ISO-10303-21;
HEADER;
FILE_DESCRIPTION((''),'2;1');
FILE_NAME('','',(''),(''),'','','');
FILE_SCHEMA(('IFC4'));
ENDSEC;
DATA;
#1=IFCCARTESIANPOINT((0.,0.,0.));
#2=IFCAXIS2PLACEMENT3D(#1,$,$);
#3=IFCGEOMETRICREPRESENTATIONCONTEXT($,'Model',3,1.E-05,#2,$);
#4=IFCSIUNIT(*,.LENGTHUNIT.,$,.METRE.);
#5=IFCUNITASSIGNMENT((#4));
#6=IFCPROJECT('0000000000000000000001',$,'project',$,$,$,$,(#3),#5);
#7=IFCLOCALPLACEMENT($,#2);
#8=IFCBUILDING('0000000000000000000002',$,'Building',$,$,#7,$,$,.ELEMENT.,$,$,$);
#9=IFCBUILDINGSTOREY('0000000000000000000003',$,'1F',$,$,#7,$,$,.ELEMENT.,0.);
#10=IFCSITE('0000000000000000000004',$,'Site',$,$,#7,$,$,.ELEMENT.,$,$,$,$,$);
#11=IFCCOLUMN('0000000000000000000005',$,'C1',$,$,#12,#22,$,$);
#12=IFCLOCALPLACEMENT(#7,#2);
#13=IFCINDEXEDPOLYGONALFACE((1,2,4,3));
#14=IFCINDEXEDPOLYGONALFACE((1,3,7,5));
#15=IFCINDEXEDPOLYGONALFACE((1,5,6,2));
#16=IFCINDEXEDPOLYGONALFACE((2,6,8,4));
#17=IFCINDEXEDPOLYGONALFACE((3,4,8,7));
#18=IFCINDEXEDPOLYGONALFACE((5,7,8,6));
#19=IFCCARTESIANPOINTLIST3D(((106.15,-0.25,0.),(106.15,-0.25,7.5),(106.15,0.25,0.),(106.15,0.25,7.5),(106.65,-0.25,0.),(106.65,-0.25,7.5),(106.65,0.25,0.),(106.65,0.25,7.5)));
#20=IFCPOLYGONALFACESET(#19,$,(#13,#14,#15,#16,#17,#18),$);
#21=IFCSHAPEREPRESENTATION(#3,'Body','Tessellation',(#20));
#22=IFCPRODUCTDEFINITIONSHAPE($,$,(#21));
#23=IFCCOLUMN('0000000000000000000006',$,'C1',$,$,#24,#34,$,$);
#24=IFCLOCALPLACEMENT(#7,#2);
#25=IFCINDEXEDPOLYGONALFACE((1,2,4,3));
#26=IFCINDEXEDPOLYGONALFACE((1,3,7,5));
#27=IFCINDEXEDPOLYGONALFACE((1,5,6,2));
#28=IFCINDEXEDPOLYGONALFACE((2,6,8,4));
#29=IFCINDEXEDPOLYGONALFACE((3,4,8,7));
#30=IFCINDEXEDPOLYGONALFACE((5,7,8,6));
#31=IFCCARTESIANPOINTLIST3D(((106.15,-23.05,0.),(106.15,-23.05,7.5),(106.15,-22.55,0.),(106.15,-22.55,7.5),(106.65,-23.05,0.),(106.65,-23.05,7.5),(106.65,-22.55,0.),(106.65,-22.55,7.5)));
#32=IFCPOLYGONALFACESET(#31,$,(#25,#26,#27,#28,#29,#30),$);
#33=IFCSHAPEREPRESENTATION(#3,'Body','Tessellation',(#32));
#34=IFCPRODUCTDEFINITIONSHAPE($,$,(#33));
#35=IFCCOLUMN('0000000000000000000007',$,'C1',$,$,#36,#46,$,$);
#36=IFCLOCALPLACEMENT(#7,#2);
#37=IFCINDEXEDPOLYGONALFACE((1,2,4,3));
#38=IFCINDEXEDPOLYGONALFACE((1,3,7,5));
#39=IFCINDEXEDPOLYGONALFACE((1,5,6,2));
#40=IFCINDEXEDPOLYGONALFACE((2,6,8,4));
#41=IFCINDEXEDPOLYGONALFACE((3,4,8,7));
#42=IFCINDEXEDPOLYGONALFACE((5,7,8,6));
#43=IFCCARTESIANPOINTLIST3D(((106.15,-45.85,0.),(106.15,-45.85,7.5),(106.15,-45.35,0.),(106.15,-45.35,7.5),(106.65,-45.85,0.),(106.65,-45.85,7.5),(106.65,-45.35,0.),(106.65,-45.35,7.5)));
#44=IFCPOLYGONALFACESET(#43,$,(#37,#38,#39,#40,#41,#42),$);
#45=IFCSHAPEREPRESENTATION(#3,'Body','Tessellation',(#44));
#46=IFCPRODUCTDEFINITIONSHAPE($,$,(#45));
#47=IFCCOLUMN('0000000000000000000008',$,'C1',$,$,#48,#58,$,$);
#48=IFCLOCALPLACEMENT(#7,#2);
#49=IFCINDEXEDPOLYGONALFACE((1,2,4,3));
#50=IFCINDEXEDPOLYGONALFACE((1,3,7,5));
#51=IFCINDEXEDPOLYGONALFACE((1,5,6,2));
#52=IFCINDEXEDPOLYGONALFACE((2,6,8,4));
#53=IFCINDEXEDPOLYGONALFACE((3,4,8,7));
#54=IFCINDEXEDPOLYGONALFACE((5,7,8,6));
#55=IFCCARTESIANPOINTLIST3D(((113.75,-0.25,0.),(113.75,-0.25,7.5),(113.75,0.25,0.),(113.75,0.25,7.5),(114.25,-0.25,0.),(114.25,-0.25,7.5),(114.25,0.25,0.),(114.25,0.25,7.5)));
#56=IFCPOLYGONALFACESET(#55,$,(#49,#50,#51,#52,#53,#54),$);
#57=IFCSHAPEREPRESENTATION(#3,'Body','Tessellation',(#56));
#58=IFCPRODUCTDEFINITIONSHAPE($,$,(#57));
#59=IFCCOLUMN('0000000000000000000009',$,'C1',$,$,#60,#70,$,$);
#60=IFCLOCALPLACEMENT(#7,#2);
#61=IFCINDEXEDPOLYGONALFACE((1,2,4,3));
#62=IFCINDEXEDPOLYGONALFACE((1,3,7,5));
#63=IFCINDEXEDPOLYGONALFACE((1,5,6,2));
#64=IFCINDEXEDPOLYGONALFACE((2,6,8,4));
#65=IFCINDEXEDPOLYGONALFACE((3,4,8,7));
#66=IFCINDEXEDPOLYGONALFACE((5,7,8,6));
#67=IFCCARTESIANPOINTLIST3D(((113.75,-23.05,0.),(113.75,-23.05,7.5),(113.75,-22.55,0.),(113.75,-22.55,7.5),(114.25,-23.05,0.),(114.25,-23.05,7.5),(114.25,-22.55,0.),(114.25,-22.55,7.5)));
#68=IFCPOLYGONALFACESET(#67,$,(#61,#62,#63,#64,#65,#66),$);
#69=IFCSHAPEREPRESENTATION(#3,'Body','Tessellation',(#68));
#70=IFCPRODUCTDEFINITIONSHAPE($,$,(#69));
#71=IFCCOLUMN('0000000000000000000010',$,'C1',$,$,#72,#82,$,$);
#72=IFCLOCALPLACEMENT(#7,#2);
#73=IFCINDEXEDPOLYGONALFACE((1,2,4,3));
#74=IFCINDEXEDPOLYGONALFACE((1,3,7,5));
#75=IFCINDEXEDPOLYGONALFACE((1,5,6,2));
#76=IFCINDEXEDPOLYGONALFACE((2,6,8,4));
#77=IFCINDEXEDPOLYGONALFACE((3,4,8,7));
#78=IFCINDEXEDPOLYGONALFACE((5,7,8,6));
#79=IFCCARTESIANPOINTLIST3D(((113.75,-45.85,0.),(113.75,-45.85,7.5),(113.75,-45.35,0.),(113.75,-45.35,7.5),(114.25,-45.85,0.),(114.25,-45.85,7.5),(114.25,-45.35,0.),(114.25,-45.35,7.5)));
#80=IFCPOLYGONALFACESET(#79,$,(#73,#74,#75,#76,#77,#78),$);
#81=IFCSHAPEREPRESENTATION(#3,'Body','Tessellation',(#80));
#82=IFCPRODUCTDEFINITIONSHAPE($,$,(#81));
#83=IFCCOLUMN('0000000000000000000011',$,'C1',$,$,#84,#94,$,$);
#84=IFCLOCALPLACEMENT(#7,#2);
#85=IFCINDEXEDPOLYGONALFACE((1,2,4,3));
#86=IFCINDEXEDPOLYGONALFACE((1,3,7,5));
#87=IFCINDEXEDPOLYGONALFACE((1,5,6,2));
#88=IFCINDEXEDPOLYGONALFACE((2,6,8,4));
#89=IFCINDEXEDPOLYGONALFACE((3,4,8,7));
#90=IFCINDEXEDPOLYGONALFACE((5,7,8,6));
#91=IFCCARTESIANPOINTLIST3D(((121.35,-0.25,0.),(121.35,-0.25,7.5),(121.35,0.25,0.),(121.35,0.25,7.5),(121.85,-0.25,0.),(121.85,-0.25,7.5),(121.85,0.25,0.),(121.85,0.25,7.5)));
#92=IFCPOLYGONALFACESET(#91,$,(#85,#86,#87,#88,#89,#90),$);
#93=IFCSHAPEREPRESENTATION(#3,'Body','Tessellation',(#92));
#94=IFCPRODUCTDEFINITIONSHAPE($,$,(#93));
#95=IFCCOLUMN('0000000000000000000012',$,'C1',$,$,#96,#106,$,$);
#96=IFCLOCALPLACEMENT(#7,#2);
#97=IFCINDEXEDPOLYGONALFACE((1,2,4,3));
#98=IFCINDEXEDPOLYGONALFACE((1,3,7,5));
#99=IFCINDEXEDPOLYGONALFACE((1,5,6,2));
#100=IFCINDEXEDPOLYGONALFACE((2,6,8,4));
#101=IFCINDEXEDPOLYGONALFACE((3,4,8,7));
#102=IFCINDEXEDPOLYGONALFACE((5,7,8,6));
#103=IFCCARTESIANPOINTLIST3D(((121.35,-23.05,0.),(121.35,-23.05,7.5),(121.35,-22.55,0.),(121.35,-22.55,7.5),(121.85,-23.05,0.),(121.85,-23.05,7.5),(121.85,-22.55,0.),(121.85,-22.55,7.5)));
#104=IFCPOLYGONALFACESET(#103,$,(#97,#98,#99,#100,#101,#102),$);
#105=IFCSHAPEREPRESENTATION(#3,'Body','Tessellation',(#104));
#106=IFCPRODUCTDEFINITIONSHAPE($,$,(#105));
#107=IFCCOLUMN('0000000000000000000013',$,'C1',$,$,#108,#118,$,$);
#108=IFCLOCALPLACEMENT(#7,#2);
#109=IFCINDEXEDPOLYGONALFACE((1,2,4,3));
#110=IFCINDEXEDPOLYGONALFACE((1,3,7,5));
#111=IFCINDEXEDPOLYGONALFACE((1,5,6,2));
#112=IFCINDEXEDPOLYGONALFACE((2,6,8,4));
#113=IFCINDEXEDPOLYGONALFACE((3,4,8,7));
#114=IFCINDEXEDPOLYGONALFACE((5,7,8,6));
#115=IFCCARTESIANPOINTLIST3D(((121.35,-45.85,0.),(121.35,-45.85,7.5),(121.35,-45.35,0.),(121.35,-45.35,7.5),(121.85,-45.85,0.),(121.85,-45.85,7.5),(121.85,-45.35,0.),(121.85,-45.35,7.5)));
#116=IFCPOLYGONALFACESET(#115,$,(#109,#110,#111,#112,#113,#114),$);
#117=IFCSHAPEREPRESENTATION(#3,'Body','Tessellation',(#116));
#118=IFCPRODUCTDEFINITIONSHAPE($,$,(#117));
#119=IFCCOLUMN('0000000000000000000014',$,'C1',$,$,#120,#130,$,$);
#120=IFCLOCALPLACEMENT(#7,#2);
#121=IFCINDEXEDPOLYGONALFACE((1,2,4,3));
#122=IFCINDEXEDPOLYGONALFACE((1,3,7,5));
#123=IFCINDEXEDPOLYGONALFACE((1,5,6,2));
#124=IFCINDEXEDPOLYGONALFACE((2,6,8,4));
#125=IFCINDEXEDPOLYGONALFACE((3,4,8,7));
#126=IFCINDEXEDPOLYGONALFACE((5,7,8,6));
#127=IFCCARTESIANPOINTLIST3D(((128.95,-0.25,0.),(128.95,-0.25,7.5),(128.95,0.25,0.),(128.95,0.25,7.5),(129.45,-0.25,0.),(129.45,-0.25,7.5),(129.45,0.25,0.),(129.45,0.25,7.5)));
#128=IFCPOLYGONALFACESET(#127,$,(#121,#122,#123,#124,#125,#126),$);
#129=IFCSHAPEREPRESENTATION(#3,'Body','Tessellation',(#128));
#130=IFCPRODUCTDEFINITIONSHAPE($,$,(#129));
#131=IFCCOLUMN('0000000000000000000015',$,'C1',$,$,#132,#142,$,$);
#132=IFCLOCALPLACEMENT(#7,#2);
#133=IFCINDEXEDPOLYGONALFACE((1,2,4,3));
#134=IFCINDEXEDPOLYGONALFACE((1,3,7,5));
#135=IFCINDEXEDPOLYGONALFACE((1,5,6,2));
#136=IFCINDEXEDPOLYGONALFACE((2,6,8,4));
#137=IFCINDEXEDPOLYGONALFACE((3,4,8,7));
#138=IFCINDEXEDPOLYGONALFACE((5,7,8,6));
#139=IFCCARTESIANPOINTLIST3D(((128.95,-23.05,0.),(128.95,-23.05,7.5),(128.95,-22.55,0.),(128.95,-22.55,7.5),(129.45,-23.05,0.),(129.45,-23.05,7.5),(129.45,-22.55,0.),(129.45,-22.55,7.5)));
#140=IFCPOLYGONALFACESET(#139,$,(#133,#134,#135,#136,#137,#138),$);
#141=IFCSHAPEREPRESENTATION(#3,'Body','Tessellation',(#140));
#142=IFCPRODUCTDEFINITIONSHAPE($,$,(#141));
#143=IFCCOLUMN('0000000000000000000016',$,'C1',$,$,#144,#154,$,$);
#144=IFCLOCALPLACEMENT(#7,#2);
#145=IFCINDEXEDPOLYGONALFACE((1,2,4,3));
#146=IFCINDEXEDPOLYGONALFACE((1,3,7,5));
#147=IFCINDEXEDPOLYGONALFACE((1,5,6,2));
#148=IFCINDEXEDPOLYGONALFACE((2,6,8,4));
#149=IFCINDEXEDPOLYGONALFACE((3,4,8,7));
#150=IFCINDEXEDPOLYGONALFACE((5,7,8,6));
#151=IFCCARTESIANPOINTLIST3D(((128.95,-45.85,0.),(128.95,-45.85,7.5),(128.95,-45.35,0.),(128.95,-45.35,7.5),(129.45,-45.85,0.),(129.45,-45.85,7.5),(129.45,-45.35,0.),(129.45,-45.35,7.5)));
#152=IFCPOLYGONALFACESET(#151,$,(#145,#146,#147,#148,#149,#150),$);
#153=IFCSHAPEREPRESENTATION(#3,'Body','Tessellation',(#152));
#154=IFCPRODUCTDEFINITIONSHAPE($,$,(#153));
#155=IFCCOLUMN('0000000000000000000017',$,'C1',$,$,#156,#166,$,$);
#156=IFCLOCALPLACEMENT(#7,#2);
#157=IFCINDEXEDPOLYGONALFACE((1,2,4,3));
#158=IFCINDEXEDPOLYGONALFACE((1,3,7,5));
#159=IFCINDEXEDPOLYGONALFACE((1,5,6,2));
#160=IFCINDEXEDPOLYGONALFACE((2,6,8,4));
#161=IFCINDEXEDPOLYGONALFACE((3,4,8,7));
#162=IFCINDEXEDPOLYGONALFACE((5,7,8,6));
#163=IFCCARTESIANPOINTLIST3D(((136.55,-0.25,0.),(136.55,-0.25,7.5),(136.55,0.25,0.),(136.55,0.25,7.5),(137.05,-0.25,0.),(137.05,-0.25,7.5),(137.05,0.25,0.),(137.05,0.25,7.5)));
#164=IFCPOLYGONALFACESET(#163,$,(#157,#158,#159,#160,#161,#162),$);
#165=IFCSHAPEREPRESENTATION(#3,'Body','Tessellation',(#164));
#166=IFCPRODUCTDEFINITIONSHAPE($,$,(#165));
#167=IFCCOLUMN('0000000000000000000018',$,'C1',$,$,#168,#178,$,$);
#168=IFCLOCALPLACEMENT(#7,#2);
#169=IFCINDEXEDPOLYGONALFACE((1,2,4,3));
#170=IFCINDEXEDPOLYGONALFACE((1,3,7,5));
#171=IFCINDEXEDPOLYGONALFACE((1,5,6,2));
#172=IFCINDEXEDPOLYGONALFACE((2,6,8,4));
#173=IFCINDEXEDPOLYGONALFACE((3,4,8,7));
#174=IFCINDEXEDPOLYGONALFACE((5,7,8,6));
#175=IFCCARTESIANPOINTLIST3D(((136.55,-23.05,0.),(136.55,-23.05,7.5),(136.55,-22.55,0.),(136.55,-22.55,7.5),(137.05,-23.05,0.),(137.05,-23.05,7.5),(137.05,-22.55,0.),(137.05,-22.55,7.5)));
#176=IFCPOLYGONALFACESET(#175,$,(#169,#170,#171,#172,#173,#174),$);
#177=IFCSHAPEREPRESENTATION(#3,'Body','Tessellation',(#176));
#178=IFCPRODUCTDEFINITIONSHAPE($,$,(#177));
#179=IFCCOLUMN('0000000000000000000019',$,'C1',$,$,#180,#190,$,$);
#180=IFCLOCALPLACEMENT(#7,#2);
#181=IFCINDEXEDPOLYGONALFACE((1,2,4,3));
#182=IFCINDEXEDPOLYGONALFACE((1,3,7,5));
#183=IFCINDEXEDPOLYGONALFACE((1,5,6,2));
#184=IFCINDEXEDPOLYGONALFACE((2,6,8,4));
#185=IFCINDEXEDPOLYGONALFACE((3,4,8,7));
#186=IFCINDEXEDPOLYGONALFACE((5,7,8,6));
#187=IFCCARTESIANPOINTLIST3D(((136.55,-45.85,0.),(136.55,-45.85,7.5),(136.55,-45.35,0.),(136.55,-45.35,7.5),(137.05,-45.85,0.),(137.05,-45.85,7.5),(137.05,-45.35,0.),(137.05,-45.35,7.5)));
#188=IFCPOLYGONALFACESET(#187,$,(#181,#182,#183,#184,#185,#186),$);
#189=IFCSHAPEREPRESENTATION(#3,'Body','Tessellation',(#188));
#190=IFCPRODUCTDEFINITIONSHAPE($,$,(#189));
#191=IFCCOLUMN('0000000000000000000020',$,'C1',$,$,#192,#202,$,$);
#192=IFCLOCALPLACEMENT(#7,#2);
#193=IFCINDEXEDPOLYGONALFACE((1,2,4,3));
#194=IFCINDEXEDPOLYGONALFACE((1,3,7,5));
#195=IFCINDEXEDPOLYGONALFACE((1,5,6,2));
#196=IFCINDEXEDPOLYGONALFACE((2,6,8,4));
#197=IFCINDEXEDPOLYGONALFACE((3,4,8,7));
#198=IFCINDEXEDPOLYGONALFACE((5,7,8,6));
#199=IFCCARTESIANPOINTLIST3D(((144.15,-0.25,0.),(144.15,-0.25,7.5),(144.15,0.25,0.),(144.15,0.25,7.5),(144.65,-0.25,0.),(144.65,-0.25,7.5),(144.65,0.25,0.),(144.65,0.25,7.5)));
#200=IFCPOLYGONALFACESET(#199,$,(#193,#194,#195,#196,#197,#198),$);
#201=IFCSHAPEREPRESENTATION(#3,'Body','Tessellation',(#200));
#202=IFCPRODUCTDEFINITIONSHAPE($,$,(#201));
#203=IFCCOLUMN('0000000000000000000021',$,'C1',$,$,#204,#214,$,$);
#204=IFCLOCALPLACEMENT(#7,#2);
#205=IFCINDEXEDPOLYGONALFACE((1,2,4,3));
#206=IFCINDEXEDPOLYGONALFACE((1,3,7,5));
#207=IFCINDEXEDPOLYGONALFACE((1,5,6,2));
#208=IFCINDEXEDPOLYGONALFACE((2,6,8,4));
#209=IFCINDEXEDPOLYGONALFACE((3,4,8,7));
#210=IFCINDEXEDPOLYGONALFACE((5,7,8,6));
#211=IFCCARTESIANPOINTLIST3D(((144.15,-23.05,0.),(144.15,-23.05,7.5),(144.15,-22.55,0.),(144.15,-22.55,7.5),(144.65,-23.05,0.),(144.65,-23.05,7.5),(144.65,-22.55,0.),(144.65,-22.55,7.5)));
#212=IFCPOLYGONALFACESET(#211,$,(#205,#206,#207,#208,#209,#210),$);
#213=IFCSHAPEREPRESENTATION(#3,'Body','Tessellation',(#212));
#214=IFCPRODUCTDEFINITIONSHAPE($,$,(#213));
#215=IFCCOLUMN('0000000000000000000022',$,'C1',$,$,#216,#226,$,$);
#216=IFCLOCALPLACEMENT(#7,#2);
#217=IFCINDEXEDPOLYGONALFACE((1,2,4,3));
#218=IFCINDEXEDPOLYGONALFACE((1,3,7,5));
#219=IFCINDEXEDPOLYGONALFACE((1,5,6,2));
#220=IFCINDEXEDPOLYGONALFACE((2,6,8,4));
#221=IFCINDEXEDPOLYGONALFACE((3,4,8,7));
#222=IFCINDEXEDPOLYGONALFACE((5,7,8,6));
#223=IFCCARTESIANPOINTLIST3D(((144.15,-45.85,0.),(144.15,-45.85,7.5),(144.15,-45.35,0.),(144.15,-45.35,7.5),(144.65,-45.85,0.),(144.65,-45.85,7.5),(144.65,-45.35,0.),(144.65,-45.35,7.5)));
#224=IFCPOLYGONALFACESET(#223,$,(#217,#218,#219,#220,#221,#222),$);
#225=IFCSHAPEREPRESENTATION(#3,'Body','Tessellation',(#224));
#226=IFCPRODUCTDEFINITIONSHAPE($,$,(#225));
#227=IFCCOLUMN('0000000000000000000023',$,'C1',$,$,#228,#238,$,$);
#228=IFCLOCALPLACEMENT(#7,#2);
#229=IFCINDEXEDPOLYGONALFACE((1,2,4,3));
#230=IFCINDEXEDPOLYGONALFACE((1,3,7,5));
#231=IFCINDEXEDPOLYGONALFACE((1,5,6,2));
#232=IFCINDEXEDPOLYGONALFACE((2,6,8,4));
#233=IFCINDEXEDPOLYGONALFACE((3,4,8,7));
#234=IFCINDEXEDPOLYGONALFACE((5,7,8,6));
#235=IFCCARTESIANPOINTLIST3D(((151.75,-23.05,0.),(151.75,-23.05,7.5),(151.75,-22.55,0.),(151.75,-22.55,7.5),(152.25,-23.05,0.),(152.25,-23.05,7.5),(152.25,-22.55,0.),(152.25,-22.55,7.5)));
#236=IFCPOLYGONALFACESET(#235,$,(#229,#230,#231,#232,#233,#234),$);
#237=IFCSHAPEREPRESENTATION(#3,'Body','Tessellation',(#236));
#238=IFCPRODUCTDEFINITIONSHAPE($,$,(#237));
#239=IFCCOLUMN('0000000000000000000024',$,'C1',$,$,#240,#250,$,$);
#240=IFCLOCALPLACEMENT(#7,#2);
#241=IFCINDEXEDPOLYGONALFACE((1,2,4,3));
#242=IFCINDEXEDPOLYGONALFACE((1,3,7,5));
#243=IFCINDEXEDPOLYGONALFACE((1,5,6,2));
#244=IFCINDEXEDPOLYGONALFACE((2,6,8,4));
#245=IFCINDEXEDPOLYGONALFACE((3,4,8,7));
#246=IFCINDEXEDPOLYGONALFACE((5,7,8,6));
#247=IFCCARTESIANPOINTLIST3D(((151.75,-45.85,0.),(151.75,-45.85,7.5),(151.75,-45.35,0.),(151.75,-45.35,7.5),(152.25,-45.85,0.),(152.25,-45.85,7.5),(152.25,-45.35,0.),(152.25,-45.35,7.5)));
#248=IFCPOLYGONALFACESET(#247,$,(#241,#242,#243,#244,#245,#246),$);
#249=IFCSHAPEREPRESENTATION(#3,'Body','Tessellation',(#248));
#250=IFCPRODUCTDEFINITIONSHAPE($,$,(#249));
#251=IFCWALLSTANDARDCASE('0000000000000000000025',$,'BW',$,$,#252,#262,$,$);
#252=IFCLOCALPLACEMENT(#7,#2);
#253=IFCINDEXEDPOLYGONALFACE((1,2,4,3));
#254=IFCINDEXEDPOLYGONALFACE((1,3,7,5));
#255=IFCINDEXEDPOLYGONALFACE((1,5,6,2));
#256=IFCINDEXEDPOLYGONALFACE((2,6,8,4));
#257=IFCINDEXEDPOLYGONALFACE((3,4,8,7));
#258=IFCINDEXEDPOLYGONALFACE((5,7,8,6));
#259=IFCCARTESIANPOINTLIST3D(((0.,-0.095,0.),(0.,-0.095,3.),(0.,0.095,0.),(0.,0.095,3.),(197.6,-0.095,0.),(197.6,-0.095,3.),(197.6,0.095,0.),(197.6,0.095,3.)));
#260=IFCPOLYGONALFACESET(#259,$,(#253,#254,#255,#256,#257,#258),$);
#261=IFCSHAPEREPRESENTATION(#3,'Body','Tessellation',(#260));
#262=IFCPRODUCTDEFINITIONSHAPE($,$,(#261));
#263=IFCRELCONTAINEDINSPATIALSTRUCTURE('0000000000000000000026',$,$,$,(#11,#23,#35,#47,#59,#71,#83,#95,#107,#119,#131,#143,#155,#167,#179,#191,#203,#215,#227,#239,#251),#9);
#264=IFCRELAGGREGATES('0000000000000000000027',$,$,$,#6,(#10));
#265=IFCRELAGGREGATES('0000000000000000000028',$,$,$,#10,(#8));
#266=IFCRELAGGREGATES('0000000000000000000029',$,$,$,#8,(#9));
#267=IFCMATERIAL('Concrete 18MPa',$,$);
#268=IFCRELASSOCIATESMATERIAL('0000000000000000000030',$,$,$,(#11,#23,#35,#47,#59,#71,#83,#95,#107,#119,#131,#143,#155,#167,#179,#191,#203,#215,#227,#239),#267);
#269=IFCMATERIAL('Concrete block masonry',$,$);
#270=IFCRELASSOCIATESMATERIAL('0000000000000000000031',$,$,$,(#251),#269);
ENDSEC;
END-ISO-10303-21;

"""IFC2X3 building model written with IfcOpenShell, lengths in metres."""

from ifc_helpers import new_model, si_unit, frame, origin, origin_2d, place, context, project, spatial, rectangle, extrude, material, element, save


model = new_model("IFC2X3")

# Units and contexts
model_context = context("Model", 3, precision=1e-05, world=origin())
ifc_project = project(units=[si_unit("LENGTHUNIT", "METRE")], contexts=[model_context])

# Site, building, storey
placement = place(None, origin())
site = spatial("IfcSite", under=ifc_project, at=placement, Name="Site", CompositionType="ELEMENT")
building = spatial("IfcBuilding", under=site, at=placement, Name="Building", CompositionType="ELEMENT")
storey = spatial("IfcBuildingStorey", under=building, at=placement, Name="1F", CompositionType="ELEMENT", Elevation=0.0)

# Columns
ifc_material_1 = material(Name="Concrete 18MPa")
for number, where, name in (
    (1, (106.4, 0.0, 0.0), "C1"),
    (2, (106.4, -22.8, 0.0), "C1"),
    (3, (106.4, -45.6, 0.0), "C1"),
    (4, (114.0, 0.0, 0.0), "C1"),
    (5, (114.0, -22.8, 0.0), "C1"),
    (6, (114.0, -45.6, 0.0), "C1"),
    (7, (121.6, 0.0, 0.0), "C1"),
    (8, (121.6, -22.8, 0.0), "C1"),
    (9, (121.6, -45.6, 0.0), "C1"),
    (10, (129.2, 0.0, 0.0), "C1"),
    (11, (129.2, -22.8, 0.0), "C1"),
    (12, (129.2, -45.6, 0.0), "C1"),
    (13, (136.8, 0.0, 0.0), "C1"),
    (14, (136.8, -22.8, 0.0), "C1"),
    (15, (136.8, -45.6, 0.0), "C1"),
    (16, (144.4, 0.0, 0.0), "C1"),
    (17, (144.4, -22.8, 0.0), "C1"),
    (18, (144.4, -45.6, 0.0), "C1"),
    (19, (152.0, -22.8, 0.0), "C1"),
    (20, (152.0, -45.6, 0.0), "C1"),
):
    element("IfcColumn", number, at=place(None, frame(where)), inside=storey, material=ifc_material_1, Name=name, context=model_context, shape_type="SweptSolid", body=[
        extrude(rectangle(XDim=0.5, YDim=0.5, at=origin_2d()), origin(), (0.0, 0.0, 1.0), 7.5),
    ])

# Wall
ifc_material_2 = material(Name="Concrete block masonry")
wall_placement = place(None, frame((98.8, 0.0, 0.0)))
element("IfcWallStandardCase", 21, at=wall_placement, inside=storey, material=ifc_material_2, Name="BW", context=model_context, shape_type="SweptSolid", body=[
    extrude(rectangle(XDim=197.6, YDim=0.19, at=origin_2d()), origin(), (0.0, 0.0, 1.0), 3.0),
])

save(model, "model.ifc")
